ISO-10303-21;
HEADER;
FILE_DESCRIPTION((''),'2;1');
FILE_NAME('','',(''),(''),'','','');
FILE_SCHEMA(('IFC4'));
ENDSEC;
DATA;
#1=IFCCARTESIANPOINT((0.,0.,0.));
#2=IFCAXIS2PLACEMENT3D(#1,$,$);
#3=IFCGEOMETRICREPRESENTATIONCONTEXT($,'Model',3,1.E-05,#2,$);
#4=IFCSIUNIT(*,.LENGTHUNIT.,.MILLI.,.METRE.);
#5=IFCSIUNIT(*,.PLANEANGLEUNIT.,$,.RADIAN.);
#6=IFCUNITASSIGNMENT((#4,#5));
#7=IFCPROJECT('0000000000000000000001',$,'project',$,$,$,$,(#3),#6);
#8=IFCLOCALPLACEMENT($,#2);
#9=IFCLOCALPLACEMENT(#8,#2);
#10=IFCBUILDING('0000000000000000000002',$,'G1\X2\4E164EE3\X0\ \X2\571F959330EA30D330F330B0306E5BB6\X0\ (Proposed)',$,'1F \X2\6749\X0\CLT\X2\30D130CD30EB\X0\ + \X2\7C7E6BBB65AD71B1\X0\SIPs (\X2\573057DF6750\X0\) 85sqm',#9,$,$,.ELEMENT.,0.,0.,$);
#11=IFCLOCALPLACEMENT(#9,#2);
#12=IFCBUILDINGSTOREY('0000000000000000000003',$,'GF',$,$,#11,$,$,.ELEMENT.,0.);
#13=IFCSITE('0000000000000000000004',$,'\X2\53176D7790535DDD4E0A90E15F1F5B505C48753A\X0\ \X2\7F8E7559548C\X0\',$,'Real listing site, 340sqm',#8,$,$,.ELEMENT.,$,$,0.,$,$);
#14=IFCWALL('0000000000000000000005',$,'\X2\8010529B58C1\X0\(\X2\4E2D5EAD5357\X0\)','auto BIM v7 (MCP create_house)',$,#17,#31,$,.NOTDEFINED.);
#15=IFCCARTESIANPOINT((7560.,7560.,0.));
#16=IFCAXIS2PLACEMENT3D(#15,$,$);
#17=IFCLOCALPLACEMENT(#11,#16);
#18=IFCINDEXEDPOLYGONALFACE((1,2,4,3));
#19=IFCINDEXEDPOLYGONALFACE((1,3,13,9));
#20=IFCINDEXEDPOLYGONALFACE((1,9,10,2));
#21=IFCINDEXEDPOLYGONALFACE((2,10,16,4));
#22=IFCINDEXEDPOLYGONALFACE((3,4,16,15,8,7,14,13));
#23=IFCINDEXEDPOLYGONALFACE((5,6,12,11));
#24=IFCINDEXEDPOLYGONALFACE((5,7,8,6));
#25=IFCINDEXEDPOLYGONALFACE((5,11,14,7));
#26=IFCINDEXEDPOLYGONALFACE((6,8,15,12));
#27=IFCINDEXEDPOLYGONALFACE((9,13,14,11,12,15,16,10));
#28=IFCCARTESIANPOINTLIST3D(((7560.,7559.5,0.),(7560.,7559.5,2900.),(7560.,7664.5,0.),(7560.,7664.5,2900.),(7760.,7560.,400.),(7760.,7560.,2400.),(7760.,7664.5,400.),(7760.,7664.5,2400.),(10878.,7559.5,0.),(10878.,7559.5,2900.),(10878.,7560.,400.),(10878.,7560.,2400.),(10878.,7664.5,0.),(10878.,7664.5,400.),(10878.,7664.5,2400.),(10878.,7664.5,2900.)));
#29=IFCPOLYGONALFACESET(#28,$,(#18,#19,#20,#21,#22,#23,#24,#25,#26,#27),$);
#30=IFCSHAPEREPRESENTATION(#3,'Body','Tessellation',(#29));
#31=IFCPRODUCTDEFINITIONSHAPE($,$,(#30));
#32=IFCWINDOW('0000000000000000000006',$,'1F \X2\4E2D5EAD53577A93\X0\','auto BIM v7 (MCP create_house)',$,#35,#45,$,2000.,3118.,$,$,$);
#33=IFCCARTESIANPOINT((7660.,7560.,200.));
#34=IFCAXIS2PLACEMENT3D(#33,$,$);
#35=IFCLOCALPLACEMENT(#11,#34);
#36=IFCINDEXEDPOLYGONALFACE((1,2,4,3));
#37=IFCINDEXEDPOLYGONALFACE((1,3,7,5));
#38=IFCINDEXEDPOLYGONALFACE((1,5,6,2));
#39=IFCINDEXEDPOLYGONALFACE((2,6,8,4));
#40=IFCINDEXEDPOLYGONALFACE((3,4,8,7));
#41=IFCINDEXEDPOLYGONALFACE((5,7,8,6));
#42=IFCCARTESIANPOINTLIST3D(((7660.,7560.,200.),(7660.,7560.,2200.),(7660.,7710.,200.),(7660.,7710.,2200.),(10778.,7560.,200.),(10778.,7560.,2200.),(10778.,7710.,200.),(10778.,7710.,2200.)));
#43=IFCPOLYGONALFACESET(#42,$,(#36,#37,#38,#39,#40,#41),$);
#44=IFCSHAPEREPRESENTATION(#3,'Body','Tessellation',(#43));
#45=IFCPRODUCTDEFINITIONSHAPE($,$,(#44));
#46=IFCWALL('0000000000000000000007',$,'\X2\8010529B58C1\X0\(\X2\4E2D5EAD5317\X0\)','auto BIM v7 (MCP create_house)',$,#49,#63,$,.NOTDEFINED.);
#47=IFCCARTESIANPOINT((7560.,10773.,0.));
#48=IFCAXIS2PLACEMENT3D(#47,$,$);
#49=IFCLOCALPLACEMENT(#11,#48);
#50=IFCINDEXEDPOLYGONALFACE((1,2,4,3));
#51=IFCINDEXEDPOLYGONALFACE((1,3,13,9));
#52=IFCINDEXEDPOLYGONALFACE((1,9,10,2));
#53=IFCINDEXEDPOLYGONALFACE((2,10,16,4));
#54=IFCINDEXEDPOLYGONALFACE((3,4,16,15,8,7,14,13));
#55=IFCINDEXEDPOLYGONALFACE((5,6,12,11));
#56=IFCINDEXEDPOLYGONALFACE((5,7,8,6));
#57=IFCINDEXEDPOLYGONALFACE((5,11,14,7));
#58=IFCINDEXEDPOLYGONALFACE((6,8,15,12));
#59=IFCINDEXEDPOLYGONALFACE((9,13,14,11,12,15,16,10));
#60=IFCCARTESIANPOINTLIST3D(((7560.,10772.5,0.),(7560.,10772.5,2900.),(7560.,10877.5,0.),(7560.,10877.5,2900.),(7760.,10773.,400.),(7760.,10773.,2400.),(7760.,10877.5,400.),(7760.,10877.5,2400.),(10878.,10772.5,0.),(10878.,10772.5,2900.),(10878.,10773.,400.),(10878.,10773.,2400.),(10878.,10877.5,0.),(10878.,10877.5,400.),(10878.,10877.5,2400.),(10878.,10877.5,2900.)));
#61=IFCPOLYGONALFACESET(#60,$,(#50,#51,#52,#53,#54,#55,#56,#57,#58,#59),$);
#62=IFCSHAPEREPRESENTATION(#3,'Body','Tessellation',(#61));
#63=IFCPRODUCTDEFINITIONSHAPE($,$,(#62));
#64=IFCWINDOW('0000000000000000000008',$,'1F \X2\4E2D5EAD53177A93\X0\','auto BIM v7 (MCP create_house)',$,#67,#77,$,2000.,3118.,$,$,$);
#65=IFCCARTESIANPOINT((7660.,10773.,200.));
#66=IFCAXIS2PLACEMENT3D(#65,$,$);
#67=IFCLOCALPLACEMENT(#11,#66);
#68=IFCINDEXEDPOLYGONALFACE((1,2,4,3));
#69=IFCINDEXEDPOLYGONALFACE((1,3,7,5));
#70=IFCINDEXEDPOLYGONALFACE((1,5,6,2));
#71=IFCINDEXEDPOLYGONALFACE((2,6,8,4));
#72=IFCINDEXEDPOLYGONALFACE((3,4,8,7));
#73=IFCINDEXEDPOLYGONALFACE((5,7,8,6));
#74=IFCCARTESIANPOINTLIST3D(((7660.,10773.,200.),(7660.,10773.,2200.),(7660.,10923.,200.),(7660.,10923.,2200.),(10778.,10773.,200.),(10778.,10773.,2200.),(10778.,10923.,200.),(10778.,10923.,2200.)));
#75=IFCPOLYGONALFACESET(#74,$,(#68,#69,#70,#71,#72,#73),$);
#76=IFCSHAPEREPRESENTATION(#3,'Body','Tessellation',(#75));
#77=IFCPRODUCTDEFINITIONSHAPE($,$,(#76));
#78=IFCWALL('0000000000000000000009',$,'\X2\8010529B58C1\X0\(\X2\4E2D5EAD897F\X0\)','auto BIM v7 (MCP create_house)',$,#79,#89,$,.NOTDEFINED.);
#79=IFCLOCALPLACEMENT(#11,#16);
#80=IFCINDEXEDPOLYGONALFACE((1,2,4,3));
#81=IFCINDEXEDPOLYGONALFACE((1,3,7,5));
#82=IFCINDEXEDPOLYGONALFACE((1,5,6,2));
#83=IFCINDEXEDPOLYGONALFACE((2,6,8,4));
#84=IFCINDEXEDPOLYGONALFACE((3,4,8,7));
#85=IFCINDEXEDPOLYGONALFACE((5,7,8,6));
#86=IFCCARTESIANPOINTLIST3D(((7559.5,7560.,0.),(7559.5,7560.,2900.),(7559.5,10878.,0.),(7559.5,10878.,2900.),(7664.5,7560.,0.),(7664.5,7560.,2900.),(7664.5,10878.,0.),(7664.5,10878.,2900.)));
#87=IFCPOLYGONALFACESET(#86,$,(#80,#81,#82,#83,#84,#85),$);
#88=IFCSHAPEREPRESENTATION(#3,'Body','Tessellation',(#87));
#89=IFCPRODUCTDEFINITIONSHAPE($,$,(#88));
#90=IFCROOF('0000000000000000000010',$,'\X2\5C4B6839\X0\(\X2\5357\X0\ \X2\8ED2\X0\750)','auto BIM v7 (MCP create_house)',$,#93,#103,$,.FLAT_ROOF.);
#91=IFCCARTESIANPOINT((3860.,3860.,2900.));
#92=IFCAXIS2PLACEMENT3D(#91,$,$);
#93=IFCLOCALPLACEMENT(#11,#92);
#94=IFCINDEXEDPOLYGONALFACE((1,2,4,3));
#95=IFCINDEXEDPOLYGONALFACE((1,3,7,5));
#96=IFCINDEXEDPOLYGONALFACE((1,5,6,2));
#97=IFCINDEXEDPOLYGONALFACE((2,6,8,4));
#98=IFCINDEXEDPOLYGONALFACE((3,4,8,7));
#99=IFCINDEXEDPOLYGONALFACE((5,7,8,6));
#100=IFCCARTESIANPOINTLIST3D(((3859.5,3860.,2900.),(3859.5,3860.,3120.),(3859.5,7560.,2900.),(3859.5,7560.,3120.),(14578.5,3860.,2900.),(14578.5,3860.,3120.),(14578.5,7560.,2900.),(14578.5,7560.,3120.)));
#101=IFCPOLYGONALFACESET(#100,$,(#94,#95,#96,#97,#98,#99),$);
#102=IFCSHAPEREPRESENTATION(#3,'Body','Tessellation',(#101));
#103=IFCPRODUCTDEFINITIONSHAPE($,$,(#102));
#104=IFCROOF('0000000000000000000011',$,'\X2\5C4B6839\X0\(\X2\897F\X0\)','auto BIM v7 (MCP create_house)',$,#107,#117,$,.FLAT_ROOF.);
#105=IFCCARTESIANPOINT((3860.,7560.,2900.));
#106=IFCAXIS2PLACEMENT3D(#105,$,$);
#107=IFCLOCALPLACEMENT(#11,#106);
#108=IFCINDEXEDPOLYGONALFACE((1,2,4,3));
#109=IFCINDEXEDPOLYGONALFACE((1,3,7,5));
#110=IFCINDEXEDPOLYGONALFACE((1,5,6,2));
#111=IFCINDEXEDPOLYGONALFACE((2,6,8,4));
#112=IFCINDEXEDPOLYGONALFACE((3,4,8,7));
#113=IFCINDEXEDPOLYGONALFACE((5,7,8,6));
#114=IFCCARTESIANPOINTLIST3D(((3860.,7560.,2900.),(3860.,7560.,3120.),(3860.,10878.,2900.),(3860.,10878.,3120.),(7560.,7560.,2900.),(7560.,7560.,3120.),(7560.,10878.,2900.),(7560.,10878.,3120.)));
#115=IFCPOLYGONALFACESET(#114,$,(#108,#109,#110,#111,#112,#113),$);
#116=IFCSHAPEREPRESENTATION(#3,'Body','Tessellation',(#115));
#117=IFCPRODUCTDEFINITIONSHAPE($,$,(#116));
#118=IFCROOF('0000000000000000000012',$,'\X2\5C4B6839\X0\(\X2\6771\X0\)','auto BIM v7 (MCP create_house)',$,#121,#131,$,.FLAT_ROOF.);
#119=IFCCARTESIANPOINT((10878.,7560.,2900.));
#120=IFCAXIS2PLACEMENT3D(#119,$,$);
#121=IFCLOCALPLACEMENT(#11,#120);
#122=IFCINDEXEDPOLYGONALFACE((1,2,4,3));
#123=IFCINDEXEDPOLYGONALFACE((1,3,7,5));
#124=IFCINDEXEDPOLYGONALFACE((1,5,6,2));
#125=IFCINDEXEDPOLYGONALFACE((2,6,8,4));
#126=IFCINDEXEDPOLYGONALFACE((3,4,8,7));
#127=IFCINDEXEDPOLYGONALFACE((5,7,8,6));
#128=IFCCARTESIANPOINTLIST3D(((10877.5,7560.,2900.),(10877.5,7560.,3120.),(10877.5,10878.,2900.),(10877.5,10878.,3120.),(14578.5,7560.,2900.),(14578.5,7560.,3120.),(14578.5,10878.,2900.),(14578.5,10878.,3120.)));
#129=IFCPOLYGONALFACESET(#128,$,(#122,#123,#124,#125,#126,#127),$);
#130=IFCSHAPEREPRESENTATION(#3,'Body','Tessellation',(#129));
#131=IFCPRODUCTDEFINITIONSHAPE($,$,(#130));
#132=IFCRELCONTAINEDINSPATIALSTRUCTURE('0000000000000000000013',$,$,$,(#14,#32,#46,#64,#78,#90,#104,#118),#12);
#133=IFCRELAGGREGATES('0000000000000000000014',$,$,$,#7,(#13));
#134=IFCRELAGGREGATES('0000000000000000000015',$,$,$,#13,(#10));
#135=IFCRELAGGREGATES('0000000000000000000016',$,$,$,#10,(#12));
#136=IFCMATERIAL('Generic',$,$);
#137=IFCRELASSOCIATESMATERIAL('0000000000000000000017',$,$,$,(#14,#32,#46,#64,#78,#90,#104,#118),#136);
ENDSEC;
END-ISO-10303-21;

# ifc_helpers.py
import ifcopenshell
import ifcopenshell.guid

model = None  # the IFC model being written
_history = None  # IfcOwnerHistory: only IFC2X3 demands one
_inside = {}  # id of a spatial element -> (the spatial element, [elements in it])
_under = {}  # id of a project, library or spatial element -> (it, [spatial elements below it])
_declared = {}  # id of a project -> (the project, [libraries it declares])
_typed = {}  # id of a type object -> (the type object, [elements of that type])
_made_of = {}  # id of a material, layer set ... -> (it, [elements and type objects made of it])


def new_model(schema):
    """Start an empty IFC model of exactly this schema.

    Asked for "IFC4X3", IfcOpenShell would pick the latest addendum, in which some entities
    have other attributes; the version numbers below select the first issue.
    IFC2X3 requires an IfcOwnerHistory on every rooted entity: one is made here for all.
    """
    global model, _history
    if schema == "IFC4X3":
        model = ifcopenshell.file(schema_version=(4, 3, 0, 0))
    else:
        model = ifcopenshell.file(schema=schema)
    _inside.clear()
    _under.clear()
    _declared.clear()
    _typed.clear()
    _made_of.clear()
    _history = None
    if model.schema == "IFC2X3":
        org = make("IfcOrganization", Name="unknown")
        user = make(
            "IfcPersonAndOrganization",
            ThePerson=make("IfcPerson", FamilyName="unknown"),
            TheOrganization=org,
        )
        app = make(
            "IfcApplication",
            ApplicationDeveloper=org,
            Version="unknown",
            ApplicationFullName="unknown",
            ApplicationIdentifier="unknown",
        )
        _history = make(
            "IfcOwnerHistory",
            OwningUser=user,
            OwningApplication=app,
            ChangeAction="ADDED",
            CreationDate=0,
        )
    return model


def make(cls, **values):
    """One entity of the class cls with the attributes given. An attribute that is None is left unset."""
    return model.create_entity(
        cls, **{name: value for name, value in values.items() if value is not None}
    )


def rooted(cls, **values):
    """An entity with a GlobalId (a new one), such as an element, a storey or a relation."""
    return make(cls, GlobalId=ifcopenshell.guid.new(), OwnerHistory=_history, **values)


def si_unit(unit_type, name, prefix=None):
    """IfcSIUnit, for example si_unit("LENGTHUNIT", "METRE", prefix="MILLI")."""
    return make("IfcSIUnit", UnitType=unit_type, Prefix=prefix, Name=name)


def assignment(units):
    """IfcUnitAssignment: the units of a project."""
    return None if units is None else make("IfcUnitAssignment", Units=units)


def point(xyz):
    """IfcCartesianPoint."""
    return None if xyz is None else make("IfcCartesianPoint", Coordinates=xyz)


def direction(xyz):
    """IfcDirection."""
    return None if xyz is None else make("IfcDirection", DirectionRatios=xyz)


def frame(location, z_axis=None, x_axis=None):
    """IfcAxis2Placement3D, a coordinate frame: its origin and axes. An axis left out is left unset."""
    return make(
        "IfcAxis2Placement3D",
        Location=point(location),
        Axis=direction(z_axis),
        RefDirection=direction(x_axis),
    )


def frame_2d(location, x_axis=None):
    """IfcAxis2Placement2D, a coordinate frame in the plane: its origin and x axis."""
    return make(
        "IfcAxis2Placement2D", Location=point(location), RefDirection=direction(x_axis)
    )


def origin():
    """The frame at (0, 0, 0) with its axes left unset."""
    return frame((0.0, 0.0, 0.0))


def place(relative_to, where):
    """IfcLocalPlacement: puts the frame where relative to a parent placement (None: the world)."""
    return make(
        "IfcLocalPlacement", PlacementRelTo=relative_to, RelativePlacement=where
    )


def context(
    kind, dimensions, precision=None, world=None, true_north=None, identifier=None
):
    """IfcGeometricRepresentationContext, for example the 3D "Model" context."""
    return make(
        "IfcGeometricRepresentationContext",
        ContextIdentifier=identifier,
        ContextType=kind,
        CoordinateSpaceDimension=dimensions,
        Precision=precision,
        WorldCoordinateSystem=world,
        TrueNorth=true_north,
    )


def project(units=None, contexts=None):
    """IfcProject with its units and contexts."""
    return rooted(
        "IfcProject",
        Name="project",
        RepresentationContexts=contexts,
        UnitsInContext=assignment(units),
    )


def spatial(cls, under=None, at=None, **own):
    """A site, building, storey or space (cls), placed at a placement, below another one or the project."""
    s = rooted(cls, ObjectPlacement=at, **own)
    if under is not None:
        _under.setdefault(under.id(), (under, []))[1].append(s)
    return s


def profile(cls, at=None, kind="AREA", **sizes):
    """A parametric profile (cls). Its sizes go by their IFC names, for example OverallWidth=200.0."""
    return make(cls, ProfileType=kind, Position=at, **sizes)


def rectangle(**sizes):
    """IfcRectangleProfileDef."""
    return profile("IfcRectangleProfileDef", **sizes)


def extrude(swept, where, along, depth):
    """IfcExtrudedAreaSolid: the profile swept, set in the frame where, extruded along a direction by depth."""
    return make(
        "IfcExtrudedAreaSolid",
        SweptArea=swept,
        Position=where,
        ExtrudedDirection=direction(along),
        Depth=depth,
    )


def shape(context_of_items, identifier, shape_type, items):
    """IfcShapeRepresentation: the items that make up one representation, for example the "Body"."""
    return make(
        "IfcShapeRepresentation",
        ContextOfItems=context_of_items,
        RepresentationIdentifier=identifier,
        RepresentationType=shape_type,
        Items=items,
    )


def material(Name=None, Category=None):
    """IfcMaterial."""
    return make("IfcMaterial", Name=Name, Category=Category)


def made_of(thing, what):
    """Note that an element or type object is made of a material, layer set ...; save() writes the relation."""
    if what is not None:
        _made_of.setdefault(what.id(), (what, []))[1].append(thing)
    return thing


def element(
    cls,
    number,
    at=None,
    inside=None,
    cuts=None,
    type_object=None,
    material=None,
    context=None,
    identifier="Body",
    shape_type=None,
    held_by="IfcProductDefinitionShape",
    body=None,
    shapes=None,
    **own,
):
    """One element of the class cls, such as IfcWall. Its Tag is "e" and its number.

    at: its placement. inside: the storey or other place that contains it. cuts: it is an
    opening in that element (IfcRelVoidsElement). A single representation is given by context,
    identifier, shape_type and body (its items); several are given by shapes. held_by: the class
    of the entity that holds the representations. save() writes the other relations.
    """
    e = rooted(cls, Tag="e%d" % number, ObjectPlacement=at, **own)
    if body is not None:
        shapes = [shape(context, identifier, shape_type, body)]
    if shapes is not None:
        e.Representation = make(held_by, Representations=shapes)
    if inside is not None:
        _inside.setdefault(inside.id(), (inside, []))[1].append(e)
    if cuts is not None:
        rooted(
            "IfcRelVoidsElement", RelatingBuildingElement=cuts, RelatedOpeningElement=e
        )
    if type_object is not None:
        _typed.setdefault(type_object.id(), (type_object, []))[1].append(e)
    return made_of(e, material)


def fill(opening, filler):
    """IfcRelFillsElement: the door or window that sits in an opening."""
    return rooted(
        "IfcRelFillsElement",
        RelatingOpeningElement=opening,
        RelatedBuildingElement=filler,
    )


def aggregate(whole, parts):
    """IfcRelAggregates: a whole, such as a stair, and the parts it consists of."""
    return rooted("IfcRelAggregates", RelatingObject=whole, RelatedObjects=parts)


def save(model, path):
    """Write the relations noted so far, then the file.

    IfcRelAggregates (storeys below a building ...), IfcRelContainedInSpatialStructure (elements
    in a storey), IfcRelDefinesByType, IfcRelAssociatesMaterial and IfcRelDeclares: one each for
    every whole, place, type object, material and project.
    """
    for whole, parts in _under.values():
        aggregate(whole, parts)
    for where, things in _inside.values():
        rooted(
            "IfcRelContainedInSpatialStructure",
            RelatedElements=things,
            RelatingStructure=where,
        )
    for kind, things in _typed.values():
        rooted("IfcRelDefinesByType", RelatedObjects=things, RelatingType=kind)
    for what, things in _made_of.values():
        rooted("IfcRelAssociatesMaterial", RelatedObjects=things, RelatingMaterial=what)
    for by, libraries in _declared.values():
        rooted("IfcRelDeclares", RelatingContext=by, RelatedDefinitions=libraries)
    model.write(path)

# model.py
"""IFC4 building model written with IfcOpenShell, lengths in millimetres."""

from ifc_helpers import new_model, si_unit, frame, frame_2d, origin, place, context, project, spatial, rectangle, extrude, material, element, fill, save


model = new_model("IFC4")

# Units and contexts
model_context = context("Model", 3, precision=1e-05, world=origin())
ifc_project = project(units=[si_unit("LENGTHUNIT", "METRE", prefix="MILLI"), si_unit("PLANEANGLEUNIT", "RADIAN")], contexts=[model_context])

# Site, building, storey
site_placement = place(None, origin())
site = spatial("IfcSite", under=ifc_project, at=site_placement, Name="北海道川上郡弟子屈町 美留和", ObjectType="Real listing site, 340sqm", CompositionType="ELEMENT", RefElevation=0.0)
building_placement = place(site_placement, origin())
building = spatial("IfcBuilding", under=site, at=building_placement, Name="G1世代 土間リビングの家 (Proposed)", ObjectType="1F 杉CLTパネル + 籾殻断熱SIPs (地域材) 85sqm", CompositionType="ELEMENT", ElevationOfRefHeight=0.0, ElevationOfTerrain=0.0)
storey_placement = place(building_placement, origin())
storey = spatial("IfcBuildingStorey", under=building, at=storey_placement, Name="GF", CompositionType="ELEMENT", Elevation=0.0)

# Shared definitions
ifc_material = material(Name="Generic")

# Walls, openings, windows
wall_1_placement = place(storey_placement, frame((7560.0, 7560.0, 0.0)))
wall_1 = element("IfcWall", 1, at=wall_1_placement, inside=storey, material=ifc_material, Name="耐力壁(中庭南)", Description="auto BIM v7 (MCP create_house)", PredefinedType="NOTDEFINED", context=model_context, shape_type="SweptSolid", body=[
    extrude(rectangle(XDim=3318.0, YDim=105.0, at=frame_2d((1659.0, 52.0))), frame((7560.0, 7560.0, 0.0)), (0.0, 0.0, 1.0), 2900.0),
])
opening_1_placement = place(storey_placement, frame((7660.0, 7560.0, 200.0)))
opening_1 = element("IfcOpeningElement", 2, at=opening_1_placement, cuts=wall_1, PredefinedType="NOTDEFINED", context=model_context, shape_type="SweptSolid", body=[
    extrude(rectangle(XDim=3118.0, YDim=150.0, at=frame_2d((1559.0, 75.0))), frame((7660.0, 7560.0, 200.0)), (0.0, 0.0, 1.0), 2000.0),
])
window_1_placement = place(storey_placement, frame((7660.0, 7560.0, 200.0)))
window_1 = element("IfcWindow", 3, at=window_1_placement, inside=storey, material=ifc_material, Name="1F 中庭南窓", Description="auto BIM v7 (MCP create_house)", OverallHeight=2000.0, OverallWidth=3118.0, context=model_context, shape_type="SweptSolid", body=[
    extrude(rectangle(XDim=3118.0, YDim=150.0, at=frame_2d((1559.0, 75.0))), frame((7660.0, 7560.0, 200.0)), (0.0, 0.0, 1.0), 2000.0),
])
fill(opening_1, window_1)
wall_2_placement = place(storey_placement, frame((7560.0, 10773.0, 0.0)))
wall_2 = element("IfcWall", 4, at=wall_2_placement, inside=storey, material=ifc_material, Name="耐力壁(中庭北)", Description="auto BIM v7 (MCP create_house)", PredefinedType="NOTDEFINED", context=model_context, shape_type="SweptSolid", body=[
    extrude(rectangle(XDim=3318.0, YDim=105.0, at=frame_2d((1659.0, 52.0))), frame((7560.0, 10773.0, 0.0)), (0.0, 0.0, 1.0), 2900.0),
])
opening_2_placement = place(storey_placement, frame((7660.0, 10773.0, 200.0)))
opening_2 = element("IfcOpeningElement", 5, at=opening_2_placement, cuts=wall_2, PredefinedType="NOTDEFINED", context=model_context, shape_type="SweptSolid", body=[
    extrude(rectangle(XDim=3118.0, YDim=150.0, at=frame_2d((1559.0, 75.0))), frame((7660.0, 10773.0, 200.0)), (0.0, 0.0, 1.0), 2000.0),
])
window_2_placement = place(storey_placement, frame((7660.0, 10773.0, 200.0)))
window_2 = element("IfcWindow", 6, at=window_2_placement, inside=storey, material=ifc_material, Name="1F 中庭北窓", Description="auto BIM v7 (MCP create_house)", OverallHeight=2000.0, OverallWidth=3118.0, context=model_context, shape_type="SweptSolid", body=[
    extrude(rectangle(XDim=3118.0, YDim=150.0, at=frame_2d((1559.0, 75.0))), frame((7660.0, 10773.0, 200.0)), (0.0, 0.0, 1.0), 2000.0),
])
fill(opening_2, window_2)

# Wall
wall_3_placement = place(storey_placement, frame((7560.0, 7560.0, 0.0)))
element("IfcWall", 7, at=wall_3_placement, inside=storey, material=ifc_material, Name="耐力壁(中庭西)", Description="auto BIM v7 (MCP create_house)", PredefinedType="NOTDEFINED", context=model_context, shape_type="SweptSolid", body=[
    extrude(rectangle(XDim=105.0, YDim=3318.0, at=frame_2d((52.0, 1659.0))), frame((7560.0, 7560.0, 0.0)), (0.0, 0.0, 1.0), 2900.0),
])

# Roofs
roof_1_placement = place(storey_placement, frame((3860.0, 3860.0, 2900.0)))
element("IfcRoof", 8, at=roof_1_placement, inside=storey, material=ifc_material, Name="屋根(南 軒750)", Description="auto BIM v7 (MCP create_house)", PredefinedType="FLAT_ROOF", context=model_context, shape_type="SweptSolid", body=[
    extrude(rectangle(XDim=10719.0, YDim=3700.0, at=frame_2d((5359.0, 1850.0))), frame((3860.0, 3860.0, 2900.0)), (0.0, 0.0, 1.0), 220.0),
])
roof_2_placement = place(storey_placement, frame((3860.0, 7560.0, 2900.0)))
element("IfcRoof", 9, at=roof_2_placement, inside=storey, material=ifc_material, Name="屋根(西)", Description="auto BIM v7 (MCP create_house)", PredefinedType="FLAT_ROOF", context=model_context, shape_type="SweptSolid", body=[
    extrude(rectangle(XDim=3700.0, YDim=3318.0, at=frame_2d((1850.0, 1659.0))), frame((3860.0, 7560.0, 2900.0)), (0.0, 0.0, 1.0), 220.0),
])
roof_3_placement = place(storey_placement, frame((10878.0, 7560.0, 2900.0)))
element("IfcRoof", 10, at=roof_3_placement, inside=storey, material=ifc_material, Name="屋根(東)", Description="auto BIM v7 (MCP create_house)", PredefinedType="FLAT_ROOF", context=model_context, shape_type="SweptSolid", body=[
    extrude(rectangle(XDim=3701.0, YDim=3318.0, at=frame_2d((1850.0, 1659.0))), frame((10878.0, 7560.0, 2900.0)), (0.0, 0.0, 1.0), 220.0),
])

save(model, "model.ifc")
